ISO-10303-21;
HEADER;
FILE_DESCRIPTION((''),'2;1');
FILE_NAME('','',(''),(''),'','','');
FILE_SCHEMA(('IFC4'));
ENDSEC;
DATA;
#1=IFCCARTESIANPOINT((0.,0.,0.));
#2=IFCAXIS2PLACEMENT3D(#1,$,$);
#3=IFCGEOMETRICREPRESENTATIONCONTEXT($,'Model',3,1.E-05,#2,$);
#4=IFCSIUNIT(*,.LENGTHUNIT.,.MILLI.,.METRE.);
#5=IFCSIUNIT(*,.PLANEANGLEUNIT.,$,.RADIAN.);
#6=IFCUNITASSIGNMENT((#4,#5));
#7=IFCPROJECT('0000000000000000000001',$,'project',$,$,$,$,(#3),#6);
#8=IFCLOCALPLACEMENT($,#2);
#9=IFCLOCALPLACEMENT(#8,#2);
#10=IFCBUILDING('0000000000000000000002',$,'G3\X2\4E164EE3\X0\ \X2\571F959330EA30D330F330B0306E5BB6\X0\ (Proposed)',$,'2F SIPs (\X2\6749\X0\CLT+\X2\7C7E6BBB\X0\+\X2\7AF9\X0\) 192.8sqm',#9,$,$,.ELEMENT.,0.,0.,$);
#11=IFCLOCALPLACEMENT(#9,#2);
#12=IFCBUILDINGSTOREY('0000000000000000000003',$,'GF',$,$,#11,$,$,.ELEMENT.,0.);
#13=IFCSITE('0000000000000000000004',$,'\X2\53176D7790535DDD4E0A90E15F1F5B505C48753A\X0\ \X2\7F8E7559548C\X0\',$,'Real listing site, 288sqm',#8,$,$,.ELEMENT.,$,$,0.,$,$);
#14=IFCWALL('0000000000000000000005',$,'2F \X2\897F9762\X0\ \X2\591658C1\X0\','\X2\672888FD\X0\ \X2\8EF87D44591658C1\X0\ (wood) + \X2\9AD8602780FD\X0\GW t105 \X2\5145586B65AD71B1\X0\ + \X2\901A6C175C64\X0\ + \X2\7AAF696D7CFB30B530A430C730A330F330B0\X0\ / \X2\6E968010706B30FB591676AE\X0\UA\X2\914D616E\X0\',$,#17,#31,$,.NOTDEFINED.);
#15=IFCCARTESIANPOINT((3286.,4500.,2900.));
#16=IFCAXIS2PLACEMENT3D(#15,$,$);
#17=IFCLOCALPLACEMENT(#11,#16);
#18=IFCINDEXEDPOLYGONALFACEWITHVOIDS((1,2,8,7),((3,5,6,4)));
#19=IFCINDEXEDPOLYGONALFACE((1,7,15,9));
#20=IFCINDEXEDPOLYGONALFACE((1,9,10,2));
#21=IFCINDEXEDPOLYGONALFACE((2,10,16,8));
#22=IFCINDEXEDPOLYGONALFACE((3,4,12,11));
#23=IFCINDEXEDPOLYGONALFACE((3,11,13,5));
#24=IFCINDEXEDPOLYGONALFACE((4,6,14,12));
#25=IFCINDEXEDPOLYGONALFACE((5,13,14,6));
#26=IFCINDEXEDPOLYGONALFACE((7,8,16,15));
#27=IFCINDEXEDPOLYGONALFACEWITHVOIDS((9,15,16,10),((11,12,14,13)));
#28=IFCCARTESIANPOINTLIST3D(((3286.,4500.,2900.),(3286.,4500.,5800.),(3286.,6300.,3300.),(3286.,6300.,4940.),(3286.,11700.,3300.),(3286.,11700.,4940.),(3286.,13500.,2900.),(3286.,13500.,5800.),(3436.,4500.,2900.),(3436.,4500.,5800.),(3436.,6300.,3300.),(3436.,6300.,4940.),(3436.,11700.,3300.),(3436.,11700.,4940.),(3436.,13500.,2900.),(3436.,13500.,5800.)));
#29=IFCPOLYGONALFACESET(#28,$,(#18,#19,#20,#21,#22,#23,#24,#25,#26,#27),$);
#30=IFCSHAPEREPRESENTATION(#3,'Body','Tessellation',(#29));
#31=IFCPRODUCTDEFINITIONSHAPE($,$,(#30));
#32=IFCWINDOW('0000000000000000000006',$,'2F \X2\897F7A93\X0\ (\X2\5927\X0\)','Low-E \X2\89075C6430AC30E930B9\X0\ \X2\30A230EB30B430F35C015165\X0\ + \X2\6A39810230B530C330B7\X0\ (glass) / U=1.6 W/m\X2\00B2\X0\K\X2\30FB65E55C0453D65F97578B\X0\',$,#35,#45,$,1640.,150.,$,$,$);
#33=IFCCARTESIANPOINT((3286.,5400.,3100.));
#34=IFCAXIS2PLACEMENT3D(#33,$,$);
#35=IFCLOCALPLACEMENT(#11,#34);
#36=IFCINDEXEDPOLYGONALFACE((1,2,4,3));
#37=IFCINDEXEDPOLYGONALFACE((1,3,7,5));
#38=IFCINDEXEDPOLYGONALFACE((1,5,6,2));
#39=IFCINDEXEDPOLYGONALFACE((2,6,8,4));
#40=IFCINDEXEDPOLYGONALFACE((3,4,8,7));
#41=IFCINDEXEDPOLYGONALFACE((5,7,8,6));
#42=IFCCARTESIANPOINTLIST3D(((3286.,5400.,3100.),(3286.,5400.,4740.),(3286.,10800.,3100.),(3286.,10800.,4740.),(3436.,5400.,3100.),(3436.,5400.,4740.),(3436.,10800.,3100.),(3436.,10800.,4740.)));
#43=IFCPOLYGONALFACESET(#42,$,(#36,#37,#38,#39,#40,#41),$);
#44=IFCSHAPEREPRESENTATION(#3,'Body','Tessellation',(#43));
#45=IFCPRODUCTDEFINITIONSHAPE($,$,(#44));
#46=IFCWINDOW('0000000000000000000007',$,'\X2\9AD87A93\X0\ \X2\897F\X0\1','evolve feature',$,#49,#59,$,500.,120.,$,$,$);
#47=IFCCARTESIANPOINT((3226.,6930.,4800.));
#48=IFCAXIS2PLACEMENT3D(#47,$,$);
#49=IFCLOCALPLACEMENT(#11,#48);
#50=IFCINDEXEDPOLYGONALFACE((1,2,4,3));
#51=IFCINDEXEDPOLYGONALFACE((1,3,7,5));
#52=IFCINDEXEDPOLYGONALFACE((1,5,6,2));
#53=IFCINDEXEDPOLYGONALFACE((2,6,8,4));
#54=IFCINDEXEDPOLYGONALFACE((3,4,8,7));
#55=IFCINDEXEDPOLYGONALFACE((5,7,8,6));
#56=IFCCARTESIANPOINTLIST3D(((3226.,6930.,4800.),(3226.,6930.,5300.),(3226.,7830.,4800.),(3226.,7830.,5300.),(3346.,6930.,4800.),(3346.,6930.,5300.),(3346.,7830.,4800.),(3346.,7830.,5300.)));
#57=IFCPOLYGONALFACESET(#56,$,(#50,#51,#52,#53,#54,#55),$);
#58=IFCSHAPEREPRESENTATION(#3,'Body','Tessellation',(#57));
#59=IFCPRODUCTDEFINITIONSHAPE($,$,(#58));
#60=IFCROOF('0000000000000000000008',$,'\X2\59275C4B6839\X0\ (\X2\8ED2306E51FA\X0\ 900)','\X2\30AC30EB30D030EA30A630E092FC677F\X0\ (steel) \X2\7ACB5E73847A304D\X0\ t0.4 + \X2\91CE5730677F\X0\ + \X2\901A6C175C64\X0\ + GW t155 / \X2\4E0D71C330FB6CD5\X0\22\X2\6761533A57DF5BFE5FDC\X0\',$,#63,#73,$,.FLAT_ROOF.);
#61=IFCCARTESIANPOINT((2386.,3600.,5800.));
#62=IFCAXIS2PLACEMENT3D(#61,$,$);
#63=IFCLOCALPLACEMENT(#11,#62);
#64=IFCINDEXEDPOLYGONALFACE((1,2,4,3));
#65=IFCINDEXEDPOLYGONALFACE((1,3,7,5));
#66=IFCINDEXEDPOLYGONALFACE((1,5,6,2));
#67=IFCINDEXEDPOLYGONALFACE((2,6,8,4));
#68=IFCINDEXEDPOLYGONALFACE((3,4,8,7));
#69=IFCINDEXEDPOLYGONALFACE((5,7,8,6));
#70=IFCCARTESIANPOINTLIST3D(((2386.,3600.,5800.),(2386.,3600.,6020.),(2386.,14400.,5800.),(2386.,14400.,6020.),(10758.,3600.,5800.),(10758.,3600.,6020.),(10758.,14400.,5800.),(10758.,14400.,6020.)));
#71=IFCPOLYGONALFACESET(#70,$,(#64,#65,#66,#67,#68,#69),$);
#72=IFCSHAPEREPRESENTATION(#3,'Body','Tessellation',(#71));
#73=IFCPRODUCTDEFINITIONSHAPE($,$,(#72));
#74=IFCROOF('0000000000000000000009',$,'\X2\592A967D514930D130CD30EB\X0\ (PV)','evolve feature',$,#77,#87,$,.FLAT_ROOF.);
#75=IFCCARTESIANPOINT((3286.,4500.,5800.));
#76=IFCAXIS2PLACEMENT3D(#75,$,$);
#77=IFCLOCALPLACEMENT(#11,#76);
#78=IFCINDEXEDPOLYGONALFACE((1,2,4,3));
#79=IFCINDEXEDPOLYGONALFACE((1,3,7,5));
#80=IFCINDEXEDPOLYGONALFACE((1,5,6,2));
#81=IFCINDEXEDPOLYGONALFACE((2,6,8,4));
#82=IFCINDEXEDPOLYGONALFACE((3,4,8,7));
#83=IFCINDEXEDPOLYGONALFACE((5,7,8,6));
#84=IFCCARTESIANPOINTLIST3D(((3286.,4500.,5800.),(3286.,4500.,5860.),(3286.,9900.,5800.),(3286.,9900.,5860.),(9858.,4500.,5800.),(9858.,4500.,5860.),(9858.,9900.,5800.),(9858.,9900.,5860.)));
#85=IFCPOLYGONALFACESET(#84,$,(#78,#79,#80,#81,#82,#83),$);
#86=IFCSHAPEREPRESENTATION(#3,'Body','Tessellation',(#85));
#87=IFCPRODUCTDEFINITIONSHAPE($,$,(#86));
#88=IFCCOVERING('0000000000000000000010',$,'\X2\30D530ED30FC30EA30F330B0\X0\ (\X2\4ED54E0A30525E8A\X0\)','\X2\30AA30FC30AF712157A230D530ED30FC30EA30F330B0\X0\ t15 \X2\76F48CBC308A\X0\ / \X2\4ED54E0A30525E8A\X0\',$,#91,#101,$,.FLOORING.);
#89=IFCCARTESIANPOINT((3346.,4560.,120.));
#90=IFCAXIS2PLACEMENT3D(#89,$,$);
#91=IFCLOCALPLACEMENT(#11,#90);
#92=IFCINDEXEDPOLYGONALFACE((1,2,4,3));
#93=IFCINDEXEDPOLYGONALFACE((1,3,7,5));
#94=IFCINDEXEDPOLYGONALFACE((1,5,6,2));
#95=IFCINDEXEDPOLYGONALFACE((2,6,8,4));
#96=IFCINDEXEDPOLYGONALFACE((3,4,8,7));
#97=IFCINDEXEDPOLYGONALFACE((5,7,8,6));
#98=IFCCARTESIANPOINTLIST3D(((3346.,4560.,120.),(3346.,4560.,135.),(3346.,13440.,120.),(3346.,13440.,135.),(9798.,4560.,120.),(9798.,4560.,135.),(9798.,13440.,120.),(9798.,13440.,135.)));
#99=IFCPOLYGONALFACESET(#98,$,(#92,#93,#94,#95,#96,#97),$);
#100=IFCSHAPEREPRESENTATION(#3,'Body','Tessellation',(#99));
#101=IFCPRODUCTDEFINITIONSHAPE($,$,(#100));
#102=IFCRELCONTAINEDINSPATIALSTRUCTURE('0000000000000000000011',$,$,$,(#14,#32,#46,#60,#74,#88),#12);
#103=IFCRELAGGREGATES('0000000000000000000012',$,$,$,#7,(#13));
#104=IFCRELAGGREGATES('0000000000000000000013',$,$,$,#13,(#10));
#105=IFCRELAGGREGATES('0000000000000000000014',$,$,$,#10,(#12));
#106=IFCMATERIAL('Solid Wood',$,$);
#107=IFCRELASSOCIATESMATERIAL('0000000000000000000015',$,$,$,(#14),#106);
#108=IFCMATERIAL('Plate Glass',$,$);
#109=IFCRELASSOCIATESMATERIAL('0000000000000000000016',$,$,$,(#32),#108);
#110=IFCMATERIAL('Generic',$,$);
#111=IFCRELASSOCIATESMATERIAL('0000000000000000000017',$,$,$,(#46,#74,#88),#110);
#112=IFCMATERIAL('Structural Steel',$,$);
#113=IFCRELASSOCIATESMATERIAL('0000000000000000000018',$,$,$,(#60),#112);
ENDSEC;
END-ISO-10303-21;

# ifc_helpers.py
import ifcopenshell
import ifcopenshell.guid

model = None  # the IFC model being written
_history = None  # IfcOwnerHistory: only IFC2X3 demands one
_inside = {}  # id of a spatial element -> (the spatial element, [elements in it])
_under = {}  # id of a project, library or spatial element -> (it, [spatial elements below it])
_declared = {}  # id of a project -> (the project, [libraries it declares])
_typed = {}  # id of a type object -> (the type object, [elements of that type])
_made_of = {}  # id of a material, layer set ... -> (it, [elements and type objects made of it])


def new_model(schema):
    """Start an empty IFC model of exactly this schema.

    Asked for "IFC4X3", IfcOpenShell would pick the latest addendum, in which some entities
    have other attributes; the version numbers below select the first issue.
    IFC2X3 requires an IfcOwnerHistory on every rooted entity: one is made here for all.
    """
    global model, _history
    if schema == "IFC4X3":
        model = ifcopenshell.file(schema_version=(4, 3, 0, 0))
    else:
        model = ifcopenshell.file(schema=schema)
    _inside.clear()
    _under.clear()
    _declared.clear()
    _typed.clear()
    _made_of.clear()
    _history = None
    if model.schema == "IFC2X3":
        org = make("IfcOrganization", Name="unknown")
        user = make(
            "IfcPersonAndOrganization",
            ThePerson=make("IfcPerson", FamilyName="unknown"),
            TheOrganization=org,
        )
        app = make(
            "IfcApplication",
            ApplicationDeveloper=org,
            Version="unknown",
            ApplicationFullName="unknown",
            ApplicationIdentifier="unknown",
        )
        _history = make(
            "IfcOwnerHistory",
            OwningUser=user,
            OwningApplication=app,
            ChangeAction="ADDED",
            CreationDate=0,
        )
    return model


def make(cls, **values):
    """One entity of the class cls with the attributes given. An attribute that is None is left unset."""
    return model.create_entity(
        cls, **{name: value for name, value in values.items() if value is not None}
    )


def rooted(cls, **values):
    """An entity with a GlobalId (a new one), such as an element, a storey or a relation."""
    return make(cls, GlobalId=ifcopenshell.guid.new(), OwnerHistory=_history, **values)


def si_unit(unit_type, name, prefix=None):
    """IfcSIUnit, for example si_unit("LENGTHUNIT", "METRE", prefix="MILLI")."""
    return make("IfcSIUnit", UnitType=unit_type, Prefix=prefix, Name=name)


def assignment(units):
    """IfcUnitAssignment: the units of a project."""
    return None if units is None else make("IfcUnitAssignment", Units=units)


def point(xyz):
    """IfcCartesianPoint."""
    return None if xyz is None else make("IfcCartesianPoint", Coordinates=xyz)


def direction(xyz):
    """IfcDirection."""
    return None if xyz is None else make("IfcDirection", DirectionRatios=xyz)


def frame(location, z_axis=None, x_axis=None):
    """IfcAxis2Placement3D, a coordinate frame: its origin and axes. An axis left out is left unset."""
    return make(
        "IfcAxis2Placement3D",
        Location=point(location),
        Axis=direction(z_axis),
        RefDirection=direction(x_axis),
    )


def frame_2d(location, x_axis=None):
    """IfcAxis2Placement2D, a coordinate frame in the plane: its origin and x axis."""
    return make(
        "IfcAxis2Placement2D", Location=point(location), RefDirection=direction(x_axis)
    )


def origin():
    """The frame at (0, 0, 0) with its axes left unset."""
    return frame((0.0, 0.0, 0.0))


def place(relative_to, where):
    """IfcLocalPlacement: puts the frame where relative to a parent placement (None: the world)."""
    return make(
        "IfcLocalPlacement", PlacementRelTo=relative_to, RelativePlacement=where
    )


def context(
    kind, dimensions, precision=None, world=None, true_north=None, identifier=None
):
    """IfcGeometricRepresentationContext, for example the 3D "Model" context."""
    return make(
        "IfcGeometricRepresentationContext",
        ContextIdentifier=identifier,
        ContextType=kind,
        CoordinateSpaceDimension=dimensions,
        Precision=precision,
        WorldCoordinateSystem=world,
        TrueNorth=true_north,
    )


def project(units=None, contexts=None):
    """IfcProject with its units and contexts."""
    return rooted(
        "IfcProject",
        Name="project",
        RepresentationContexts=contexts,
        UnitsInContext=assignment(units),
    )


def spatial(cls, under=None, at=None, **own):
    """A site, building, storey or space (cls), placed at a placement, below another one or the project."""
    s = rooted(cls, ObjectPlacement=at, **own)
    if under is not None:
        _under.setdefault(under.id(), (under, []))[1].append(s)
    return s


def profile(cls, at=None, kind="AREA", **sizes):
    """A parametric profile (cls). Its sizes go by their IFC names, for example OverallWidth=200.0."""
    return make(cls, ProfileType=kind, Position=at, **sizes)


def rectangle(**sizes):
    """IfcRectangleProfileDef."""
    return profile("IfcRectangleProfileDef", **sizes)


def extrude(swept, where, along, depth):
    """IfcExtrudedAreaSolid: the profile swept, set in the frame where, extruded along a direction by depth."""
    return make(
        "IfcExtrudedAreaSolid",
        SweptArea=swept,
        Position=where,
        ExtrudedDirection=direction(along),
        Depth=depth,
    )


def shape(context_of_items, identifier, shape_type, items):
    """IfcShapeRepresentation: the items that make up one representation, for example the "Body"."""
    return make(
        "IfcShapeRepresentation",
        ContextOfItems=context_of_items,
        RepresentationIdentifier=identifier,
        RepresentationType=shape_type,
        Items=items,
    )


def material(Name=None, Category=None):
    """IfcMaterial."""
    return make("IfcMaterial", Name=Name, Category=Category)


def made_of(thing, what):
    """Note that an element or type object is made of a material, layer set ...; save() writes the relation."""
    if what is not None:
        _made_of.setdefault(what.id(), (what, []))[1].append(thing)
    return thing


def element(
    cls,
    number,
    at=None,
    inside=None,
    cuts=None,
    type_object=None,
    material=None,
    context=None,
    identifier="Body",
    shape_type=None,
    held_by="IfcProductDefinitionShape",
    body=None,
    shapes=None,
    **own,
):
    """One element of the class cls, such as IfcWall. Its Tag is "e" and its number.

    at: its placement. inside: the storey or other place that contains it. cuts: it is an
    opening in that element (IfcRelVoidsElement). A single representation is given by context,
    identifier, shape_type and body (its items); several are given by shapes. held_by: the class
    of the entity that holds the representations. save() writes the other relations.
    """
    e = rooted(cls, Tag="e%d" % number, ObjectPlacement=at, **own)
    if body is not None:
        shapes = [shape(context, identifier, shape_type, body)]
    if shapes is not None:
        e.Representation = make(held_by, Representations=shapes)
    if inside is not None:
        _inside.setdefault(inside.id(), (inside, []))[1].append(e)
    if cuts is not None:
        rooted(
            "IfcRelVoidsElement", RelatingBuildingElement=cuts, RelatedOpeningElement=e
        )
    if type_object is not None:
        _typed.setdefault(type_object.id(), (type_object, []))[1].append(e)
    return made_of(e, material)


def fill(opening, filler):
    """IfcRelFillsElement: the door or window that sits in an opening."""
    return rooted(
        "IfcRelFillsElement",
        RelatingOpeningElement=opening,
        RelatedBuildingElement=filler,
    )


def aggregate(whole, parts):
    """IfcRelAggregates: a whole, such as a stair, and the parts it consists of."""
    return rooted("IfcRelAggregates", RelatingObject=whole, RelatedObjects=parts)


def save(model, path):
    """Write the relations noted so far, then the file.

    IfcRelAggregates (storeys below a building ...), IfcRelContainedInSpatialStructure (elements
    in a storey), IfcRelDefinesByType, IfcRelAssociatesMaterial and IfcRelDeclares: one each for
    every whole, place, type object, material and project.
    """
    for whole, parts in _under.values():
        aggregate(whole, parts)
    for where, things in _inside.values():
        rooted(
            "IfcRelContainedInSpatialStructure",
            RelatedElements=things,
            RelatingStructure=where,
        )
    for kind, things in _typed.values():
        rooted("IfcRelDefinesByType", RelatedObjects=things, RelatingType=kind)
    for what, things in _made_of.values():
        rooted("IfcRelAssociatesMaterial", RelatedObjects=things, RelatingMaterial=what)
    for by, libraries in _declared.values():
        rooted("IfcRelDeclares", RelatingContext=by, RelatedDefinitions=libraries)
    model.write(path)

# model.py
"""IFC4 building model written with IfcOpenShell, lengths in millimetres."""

from ifc_helpers import new_model, si_unit, frame, frame_2d, origin, place, context, project, spatial, rectangle, extrude, material, element, fill, save


model = new_model("IFC4")

# Units and contexts
model_context = context("Model", 3, precision=1e-05, world=origin())
ifc_project = project(units=[si_unit("LENGTHUNIT", "METRE", prefix="MILLI"), si_unit("PLANEANGLEUNIT", "RADIAN")], contexts=[model_context])

# Site, building, storey
site_placement = place(None, origin())
site = spatial("IfcSite", under=ifc_project, at=site_placement, Name="北海道川上郡弟子屈町 美留和", ObjectType="Real listing site, 288sqm", CompositionType="ELEMENT", RefElevation=0.0)
building_placement = place(site_placement, origin())
building = spatial("IfcBuilding", under=site, at=building_placement, Name="G3世代 土間リビングの家 (Proposed)", ObjectType="2F SIPs (杉CLT+籾殻+竹) 192.8sqm", CompositionType="ELEMENT", ElevationOfRefHeight=0.0, ElevationOfTerrain=0.0)
storey_placement = place(building_placement, origin())
storey = spatial("IfcBuildingStorey", under=building, at=storey_placement, Name="GF", CompositionType="ELEMENT", Elevation=0.0)

# Shared definitions
ifc_material_1 = material(Name="Solid Wood")

# Shared definitions
ifc_material_2 = material(Name="Plate Glass")
ifc_material_3 = material(Name="Generic")

# Wall, openings, windows
wall_1_placement = place(storey_placement, frame((3286.0, 4500.0, 2900.0)))
wall_1 = element("IfcWall", 1, at=wall_1_placement, inside=storey, material=ifc_material_1, Name="2F 西面 外壁", Description="木製 軸組外壁 (wood) + 高性能GW t105 充填断熱 + 通気層 + 窯業系サイディング / 準耐火・外皮UA配慮", PredefinedType="NOTDEFINED", context=model_context, shape_type="SweptSolid", body=[
    extrude(rectangle(XDim=150.0, YDim=9000.0, at=frame_2d((75.0, 4500.0))), frame((3286.0, 4500.0, 2900.0)), (0.0, 0.0, 1.0), 2900.0),
])
opening_1_placement = place(storey_placement, frame((3286.0, 5400.0, 3100.0)))
opening_1 = element("IfcOpeningElement", 2, at=opening_1_placement, cuts=wall_1, PredefinedType="NOTDEFINED", context=model_context, shape_type="SweptSolid", body=[
    extrude(rectangle(XDim=150.0, YDim=5400.0, at=frame_2d((75.0, 2700.0))), frame((3286.0, 5400.0, 3100.0)), (0.0, 0.0, 1.0), 1640.0),
])
opening_2_placement = place(storey_placement, frame((3226.0, 6930.0, 4800.0)))
opening_2 = element("IfcOpeningElement", 3, at=opening_2_placement, cuts=wall_1, PredefinedType="NOTDEFINED", context=model_context, shape_type="SweptSolid", body=[
    extrude(rectangle(XDim=120.0, YDim=900.0, at=frame_2d((60.0, 450.0))), frame((3226.0, 6930.0, 4800.0)), (0.0, 0.0, 1.0), 500.0),
])
window_1_placement = place(storey_placement, frame((3286.0, 5400.0, 3100.0)))
window_1 = element("IfcWindow", 4, at=window_1_placement, inside=storey, material=ifc_material_2, Name="2F 西窓 (大)", Description="Low-E 複層ガラス アルゴン封入 + 樹脂サッシ (glass) / U=1.6 W/m²K・日射取得型", OverallHeight=1640.0, OverallWidth=150.0, context=model_context, shape_type="SweptSolid", body=[
    extrude(rectangle(XDim=150.0, YDim=5400.0, at=frame_2d((75.0, 2700.0))), frame((3286.0, 5400.0, 3100.0)), (0.0, 0.0, 1.0), 1640.0),
])
fill(opening_1, window_1)
window_2_placement = place(storey_placement, frame((3226.0, 6930.0, 4800.0)))
window_2 = element("IfcWindow", 5, at=window_2_placement, inside=storey, material=ifc_material_3, Name="高窓 西1", Description="evolve feature", OverallHeight=500.0, OverallWidth=120.0, context=model_context, shape_type="SweptSolid", body=[
    extrude(rectangle(XDim=120.0, YDim=900.0, at=frame_2d((60.0, 450.0))), frame((3226.0, 6930.0, 4800.0)), (0.0, 0.0, 1.0), 500.0),
])
fill(opening_2, window_2)

# Roofs
ifc_material_4 = material(Name="Structural Steel")
roof_1_placement = place(storey_placement, frame((2386.0, 3600.0, 5800.0)))
element("IfcRoof", 6, at=roof_1_placement, inside=storey, material=ifc_material_4, Name="大屋根 (軒の出 900)", Description="ガルバリウム鋼板 (steel) 立平葺き t0.4 + 野地板 + 通気層 + GW t155 / 不燃・法22条区域対応", PredefinedType="FLAT_ROOF", context=model_context, shape_type="SweptSolid", body=[
    extrude(rectangle(XDim=8372.0, YDim=10800.0, at=frame_2d((4186.0, 5400.0))), frame((2386.0, 3600.0, 5800.0)), (0.0, 0.0, 1.0), 220.0),
])
roof_2_placement = place(storey_placement, frame((3286.0, 4500.0, 5800.0)))
element("IfcRoof", 7, at=roof_2_placement, inside=storey, material=ifc_material_3, Name="太陽光パネル (PV)", Description="evolve feature", PredefinedType="FLAT_ROOF", context=model_context, shape_type="SweptSolid", body=[
    extrude(rectangle(XDim=6572.0, YDim=5400.0, at=frame_2d((3286.0, 2700.0))), frame((3286.0, 4500.0, 5800.0)), (0.0, 0.0, 1.0), 60.0),
])

# Covering
covering_placement = place(storey_placement, frame((3346.0, 4560.0, 120.0)))
element("IfcCovering", 8, at=covering_placement, inside=storey, material=ifc_material_3, Name="フローリング (仕上げ床)", Description="オーク無垢フローリング t15 直貼り / 仕上げ床", PredefinedType="FLOORING", context=model_context, shape_type="SweptSolid", body=[
    extrude(rectangle(XDim=6452.0, YDim=8880.0, at=frame_2d((3226.0, 4440.0))), frame((3346.0, 4560.0, 120.0)), (0.0, 0.0, 1.0), 15.0),
])

save(model, "model.ifc")
